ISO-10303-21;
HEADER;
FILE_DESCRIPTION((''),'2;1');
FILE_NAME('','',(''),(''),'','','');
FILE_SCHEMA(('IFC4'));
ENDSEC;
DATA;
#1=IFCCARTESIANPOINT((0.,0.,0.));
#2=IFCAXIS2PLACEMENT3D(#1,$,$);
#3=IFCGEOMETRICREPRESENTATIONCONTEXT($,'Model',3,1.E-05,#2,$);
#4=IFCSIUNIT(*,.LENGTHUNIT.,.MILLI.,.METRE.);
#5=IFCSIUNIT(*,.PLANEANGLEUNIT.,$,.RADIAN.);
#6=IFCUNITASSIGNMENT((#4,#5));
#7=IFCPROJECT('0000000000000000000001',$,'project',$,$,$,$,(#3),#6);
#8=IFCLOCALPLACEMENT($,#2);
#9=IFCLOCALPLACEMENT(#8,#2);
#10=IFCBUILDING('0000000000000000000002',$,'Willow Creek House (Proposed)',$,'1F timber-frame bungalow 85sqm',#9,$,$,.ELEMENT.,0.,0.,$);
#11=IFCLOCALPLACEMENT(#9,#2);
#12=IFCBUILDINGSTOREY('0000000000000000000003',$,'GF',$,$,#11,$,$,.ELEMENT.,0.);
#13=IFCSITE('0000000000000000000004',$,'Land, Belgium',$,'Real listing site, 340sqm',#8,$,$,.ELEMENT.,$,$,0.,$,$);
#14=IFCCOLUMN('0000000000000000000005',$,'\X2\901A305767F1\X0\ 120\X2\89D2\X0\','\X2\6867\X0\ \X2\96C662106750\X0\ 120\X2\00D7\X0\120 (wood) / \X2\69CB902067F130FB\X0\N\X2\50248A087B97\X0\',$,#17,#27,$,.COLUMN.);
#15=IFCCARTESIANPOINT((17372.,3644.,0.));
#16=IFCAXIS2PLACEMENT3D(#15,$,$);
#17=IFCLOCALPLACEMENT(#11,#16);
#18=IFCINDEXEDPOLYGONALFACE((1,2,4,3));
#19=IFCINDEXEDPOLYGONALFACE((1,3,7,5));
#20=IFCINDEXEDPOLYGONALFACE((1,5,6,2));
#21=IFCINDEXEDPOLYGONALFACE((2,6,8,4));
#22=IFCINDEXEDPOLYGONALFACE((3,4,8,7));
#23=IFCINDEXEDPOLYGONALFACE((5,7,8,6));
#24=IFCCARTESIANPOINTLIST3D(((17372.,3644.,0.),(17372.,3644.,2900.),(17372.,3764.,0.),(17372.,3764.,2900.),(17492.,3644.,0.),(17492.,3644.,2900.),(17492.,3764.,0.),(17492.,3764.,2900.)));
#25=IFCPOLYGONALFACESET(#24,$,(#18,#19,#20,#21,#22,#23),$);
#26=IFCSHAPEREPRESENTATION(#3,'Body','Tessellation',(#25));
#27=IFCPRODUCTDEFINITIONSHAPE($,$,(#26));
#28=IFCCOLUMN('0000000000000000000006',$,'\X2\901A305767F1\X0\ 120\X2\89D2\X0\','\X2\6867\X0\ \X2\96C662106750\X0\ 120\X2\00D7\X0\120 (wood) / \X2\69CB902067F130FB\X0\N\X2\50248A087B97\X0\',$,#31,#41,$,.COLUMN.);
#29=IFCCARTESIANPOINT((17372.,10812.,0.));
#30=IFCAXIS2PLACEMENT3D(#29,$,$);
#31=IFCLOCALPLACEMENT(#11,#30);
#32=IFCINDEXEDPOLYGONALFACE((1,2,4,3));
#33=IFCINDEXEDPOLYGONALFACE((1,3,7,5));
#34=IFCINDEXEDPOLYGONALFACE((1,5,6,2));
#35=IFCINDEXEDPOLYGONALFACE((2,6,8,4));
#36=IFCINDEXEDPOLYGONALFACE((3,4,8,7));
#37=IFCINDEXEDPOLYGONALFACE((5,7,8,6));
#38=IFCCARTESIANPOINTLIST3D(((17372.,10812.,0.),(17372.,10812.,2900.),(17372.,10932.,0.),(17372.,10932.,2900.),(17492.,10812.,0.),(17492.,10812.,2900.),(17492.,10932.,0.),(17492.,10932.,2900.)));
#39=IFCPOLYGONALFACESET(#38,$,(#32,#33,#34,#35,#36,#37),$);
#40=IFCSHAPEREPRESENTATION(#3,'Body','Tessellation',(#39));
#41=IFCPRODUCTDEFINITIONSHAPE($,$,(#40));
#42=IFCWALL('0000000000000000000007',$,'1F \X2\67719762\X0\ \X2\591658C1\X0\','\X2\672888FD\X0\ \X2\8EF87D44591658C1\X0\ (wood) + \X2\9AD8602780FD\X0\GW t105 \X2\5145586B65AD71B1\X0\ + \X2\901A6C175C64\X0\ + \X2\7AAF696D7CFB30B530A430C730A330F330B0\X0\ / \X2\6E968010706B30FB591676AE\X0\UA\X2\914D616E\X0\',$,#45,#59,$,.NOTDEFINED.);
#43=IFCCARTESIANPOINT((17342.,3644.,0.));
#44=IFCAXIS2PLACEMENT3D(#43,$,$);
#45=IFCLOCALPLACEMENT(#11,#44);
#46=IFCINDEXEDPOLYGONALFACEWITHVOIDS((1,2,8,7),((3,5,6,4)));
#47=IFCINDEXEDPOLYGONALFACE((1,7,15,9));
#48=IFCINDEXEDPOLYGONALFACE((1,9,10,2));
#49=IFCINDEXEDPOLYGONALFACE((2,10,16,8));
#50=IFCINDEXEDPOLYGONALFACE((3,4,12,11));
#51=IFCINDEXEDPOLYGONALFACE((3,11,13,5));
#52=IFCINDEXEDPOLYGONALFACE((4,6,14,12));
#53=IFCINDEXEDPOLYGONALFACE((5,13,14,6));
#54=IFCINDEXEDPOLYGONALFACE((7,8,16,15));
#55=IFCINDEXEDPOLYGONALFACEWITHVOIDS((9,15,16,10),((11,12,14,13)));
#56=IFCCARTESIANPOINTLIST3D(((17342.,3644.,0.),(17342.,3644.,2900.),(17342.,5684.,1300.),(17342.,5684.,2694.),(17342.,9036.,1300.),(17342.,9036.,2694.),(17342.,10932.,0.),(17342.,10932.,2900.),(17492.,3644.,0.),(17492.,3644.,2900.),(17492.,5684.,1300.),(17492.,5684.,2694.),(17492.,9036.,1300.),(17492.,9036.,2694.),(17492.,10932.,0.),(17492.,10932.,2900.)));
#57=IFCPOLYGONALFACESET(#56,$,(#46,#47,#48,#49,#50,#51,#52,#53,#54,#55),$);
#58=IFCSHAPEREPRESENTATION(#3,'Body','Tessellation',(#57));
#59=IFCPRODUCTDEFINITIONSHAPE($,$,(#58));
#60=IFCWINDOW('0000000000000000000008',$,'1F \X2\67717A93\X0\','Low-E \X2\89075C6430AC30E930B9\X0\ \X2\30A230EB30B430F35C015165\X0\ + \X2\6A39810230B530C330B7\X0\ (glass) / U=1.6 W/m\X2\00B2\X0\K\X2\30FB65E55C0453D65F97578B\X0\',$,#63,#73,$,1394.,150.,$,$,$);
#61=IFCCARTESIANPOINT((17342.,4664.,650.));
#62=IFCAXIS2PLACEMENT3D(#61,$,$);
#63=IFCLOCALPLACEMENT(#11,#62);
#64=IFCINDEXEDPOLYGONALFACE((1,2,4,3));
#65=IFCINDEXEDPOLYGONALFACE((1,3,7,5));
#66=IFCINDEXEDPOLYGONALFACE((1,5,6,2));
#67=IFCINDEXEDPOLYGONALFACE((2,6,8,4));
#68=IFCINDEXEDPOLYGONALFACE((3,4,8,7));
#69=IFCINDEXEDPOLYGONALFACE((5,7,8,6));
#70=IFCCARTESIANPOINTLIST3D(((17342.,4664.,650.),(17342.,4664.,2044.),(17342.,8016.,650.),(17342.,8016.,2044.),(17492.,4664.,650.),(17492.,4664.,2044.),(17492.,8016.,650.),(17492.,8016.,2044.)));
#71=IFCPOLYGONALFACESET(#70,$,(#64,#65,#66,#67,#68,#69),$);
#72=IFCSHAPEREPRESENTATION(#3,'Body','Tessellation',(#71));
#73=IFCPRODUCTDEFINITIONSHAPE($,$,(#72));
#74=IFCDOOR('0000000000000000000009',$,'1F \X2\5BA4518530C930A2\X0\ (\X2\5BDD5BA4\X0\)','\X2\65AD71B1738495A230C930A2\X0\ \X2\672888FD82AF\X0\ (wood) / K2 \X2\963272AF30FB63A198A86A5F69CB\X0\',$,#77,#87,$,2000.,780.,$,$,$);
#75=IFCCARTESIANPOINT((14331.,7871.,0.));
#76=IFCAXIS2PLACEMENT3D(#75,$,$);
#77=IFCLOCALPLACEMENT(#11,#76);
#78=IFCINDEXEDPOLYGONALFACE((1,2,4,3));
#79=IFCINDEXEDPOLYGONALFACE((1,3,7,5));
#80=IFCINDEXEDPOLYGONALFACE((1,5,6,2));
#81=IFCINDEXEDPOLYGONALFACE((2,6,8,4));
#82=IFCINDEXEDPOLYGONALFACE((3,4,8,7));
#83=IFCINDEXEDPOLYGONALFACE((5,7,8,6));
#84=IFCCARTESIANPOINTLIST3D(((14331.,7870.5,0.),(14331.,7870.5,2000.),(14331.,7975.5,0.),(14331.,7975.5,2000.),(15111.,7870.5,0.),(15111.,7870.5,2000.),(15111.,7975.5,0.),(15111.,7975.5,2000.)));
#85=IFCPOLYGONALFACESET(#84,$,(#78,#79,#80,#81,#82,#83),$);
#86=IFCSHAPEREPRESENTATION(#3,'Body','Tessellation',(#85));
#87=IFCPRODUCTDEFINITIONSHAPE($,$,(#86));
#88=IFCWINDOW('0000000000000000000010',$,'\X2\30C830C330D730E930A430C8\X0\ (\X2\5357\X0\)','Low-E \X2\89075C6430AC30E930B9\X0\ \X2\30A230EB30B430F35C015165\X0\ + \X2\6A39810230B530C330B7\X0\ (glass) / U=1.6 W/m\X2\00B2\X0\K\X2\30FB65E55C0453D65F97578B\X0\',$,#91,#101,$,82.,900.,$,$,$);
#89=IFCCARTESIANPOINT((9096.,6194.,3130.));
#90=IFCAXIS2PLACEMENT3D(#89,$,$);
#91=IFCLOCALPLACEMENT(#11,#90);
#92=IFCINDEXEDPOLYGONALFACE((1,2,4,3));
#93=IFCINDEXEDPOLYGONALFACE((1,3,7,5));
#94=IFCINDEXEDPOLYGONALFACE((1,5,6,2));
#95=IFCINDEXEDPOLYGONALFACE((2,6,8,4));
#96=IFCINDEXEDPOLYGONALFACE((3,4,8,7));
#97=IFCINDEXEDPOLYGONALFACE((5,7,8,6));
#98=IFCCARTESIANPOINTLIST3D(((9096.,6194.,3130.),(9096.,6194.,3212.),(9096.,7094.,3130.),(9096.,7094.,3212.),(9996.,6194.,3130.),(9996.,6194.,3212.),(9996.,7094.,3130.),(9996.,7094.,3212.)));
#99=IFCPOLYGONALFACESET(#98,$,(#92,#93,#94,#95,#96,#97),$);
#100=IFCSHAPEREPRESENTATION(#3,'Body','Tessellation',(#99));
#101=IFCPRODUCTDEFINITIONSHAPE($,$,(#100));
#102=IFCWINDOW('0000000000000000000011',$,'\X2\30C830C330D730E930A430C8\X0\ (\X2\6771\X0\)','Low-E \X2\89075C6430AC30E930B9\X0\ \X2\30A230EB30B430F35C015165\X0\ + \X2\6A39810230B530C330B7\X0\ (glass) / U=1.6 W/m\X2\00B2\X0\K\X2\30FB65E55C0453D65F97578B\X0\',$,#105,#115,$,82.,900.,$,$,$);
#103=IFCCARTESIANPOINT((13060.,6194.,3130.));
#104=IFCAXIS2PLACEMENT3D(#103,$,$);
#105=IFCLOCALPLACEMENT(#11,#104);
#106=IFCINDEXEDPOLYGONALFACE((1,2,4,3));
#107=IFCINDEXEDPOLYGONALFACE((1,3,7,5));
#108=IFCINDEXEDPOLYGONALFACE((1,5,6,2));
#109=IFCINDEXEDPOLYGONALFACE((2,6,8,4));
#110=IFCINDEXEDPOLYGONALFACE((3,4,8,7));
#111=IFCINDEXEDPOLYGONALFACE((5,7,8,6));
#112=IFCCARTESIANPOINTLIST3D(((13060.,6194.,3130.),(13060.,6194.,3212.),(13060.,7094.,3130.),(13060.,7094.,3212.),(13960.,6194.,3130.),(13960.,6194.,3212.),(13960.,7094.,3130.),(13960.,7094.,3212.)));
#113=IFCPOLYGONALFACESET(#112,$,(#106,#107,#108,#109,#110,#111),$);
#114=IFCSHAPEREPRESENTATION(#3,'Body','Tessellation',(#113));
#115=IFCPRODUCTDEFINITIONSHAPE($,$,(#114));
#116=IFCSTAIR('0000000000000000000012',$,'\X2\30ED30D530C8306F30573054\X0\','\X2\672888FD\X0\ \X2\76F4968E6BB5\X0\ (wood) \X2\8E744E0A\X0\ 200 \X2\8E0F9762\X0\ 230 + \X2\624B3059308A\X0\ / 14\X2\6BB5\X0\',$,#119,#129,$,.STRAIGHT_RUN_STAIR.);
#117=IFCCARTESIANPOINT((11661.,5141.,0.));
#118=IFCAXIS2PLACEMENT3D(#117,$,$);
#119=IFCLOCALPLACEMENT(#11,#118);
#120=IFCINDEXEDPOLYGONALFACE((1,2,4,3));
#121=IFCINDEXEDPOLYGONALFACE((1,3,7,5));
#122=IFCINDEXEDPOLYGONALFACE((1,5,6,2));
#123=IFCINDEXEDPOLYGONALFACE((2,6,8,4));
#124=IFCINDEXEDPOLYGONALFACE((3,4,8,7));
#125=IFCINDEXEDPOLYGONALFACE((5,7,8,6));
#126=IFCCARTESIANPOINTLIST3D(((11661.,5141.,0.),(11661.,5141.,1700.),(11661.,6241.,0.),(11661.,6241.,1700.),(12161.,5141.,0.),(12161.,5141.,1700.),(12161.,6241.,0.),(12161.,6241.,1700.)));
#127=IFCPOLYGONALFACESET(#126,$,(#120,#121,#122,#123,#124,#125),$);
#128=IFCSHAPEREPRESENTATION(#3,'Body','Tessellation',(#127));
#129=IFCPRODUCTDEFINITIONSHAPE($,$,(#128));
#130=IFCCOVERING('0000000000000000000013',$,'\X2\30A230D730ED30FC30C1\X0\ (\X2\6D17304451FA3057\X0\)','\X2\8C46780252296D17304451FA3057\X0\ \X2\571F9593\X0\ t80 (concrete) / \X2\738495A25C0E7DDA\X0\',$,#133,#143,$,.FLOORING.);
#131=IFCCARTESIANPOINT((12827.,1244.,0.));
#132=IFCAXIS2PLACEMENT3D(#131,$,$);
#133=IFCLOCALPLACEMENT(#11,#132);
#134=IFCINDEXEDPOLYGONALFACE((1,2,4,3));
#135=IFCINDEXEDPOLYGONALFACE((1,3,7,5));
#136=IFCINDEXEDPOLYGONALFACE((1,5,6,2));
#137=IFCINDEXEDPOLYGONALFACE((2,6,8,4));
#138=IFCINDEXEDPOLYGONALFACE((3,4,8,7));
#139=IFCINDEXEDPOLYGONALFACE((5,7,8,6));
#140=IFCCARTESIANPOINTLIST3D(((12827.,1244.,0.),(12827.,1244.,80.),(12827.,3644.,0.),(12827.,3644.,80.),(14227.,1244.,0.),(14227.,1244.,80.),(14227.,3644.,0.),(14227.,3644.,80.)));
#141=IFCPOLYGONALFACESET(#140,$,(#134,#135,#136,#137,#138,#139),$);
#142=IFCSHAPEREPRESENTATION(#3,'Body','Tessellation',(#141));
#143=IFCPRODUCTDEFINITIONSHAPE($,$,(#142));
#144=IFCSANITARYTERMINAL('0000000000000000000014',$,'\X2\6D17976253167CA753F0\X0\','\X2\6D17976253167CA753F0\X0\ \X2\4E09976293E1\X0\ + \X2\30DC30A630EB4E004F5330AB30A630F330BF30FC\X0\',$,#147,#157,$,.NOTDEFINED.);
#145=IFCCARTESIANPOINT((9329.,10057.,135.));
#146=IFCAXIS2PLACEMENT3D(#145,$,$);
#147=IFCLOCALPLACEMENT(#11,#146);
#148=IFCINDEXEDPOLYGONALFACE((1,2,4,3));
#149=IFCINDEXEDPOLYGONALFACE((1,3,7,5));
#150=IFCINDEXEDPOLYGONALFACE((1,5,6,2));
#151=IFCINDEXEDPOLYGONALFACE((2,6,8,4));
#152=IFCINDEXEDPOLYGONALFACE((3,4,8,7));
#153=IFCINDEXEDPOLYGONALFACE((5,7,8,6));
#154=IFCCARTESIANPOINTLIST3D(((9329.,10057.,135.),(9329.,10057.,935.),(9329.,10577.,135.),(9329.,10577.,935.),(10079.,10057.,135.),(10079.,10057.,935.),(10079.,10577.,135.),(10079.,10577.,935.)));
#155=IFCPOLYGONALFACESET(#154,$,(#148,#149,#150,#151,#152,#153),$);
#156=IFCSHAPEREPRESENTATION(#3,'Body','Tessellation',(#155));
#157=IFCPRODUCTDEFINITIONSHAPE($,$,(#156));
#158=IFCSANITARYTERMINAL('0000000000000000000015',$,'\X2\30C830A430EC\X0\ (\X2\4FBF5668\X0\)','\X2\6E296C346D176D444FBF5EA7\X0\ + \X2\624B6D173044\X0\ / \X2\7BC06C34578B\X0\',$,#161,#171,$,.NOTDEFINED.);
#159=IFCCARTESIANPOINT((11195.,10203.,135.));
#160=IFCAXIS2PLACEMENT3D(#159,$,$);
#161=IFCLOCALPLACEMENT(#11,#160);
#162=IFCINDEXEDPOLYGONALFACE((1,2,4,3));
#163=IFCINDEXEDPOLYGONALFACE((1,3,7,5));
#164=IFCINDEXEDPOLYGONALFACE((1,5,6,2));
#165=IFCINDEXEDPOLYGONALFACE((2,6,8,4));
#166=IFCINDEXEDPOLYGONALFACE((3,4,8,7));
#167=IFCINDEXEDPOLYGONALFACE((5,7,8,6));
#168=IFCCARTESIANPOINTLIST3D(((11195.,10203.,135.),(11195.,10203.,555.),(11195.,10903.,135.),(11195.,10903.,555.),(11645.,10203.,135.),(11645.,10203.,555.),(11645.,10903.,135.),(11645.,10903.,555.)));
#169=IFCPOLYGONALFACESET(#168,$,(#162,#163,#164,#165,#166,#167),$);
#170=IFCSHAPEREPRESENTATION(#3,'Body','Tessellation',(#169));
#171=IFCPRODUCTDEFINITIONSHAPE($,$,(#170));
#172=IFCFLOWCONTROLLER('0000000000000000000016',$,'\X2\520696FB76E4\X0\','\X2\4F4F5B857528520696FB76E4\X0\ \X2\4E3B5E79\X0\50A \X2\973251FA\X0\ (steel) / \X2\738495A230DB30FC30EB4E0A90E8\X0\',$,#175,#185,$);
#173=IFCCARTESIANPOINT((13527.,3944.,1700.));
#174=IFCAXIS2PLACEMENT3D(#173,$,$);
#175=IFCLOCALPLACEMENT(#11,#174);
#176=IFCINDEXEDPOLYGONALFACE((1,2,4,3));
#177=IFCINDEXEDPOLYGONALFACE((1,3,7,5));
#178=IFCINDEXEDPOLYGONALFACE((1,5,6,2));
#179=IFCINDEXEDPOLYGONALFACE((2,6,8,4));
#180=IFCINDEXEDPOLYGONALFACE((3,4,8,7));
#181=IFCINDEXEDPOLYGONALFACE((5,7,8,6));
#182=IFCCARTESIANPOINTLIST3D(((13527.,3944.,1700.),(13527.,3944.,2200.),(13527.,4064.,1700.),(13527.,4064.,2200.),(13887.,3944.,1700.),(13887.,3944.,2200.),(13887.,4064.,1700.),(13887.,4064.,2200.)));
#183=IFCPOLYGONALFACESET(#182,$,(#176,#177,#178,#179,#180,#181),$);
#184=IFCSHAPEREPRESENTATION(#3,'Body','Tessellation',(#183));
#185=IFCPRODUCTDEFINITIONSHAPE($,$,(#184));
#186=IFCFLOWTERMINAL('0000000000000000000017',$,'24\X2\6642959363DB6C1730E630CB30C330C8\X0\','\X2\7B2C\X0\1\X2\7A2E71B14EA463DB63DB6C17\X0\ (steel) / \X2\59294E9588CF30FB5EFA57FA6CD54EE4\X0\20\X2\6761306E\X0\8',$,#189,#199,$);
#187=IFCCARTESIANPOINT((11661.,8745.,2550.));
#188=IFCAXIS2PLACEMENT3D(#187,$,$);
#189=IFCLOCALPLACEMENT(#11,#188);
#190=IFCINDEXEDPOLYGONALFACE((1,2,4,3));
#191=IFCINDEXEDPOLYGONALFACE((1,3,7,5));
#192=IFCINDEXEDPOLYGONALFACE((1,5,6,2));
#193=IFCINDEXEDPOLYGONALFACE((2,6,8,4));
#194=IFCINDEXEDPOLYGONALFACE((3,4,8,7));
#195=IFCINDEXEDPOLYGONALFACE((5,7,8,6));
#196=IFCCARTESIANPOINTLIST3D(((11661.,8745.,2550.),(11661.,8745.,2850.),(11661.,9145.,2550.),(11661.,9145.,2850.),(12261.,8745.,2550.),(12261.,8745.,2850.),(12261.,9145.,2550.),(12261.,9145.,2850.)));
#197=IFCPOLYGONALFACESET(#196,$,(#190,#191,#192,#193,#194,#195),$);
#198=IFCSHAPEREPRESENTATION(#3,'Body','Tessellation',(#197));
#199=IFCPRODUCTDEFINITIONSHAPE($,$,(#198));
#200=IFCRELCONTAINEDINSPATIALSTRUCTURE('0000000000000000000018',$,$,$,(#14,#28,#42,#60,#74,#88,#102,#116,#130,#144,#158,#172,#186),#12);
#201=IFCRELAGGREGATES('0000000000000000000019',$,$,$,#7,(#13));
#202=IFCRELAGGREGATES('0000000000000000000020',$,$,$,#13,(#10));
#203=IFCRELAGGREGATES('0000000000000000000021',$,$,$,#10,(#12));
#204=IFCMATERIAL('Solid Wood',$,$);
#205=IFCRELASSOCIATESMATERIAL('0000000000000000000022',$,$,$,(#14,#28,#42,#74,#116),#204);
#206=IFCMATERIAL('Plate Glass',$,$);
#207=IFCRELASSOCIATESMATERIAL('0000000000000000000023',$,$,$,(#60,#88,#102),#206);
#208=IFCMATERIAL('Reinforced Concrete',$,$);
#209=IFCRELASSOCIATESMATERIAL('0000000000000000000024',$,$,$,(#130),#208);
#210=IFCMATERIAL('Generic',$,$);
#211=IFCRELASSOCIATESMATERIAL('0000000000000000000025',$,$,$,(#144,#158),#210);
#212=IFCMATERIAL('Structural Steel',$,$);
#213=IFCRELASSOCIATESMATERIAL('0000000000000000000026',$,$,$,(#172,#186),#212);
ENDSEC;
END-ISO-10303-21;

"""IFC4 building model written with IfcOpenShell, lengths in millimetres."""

from ifc_helpers import new_model, si_unit, frame, frame_2d, origin, place, context, project, spatial, rectangle, extrude, material, element, fill, save


model = new_model("IFC4")

# Units and contexts
model_context = context("Model", 3, precision=1e-05, world=origin())
ifc_project = project(units=[si_unit("LENGTHUNIT", "METRE", prefix="MILLI"), si_unit("PLANEANGLEUNIT", "RADIAN")], contexts=[model_context])

# Site, building, storey
site_placement = place(None, origin())
site = spatial("IfcSite", under=ifc_project, at=site_placement, Name="Land, Belgium", ObjectType="Real listing site, 340sqm", CompositionType="ELEMENT", RefElevation=0.0)
building_placement = place(site_placement, origin())
building = spatial("IfcBuilding", under=site, at=building_placement, Name="Willow Creek House (Proposed)", ObjectType="1F timber-frame bungalow 85sqm", CompositionType="ELEMENT", ElevationOfRefHeight=0.0, ElevationOfTerrain=0.0)
storey_placement = place(building_placement, origin())
storey = spatial("IfcBuildingStorey", under=building, at=storey_placement, Name="GF", CompositionType="ELEMENT", Elevation=0.0)

# Columns
ifc_material_1 = material(Name="Solid Wood")
column_1_placement = place(storey_placement, frame((17372.0, 3644.0, 0.0)))
element("IfcColumn", 1, at=column_1_placement, inside=storey, material=ifc_material_1, Name="通し柱 120角", Description="桧 集成材 120×120 (wood) / 構造柱・N値計算", PredefinedType="COLUMN", context=model_context, shape_type="SweptSolid", body=[
    extrude(rectangle(XDim=120.0, YDim=120.0, at=frame_2d((60.0, 60.0))), frame((17372.0, 3644.0, 0.0)), (0.0, 0.0, 1.0), 2900.0),
])
column_2_placement = place(storey_placement, frame((17372.0, 10812.0, 0.0)))
element("IfcColumn", 2, at=column_2_placement, inside=storey, material=ifc_material_1, Name="通し柱 120角", Description="桧 集成材 120×120 (wood) / 構造柱・N値計算", PredefinedType="COLUMN", context=model_context, shape_type="SweptSolid", body=[
    extrude(rectangle(XDim=120.0, YDim=120.0, at=frame_2d((60.0, 60.0))), frame((17372.0, 10812.0, 0.0)), (0.0, 0.0, 1.0), 2900.0),
])

# Wall, opening, window
wall_1_placement = place(storey_placement, frame((17342.0, 3644.0, 0.0)))
wall_1 = element("IfcWall", 3, at=wall_1_placement, inside=storey, material=ifc_material_1, Name="1F 東面 外壁", Description="木製 軸組外壁 (wood) + 高性能GW t105 充填断熱 + 通気層 + 窯業系サイディング / 準耐火・外皮UA配慮", PredefinedType="NOTDEFINED", context=model_context, shape_type="SweptSolid", body=[
    extrude(rectangle(XDim=150.0, YDim=7288.0, at=frame_2d((75.0, 3644.0))), frame((17342.0, 3644.0, 0.0)), (0.0, 0.0, 1.0), 2900.0),
])
opening_placement = place(storey_placement, frame((17342.0, 4664.0, 650.0)))
opening = element("IfcOpeningElement", 4, at=opening_placement, cuts=wall_1, PredefinedType="NOTDEFINED", context=model_context, shape_type="SweptSolid", body=[
    extrude(rectangle(XDim=150.0, YDim=3352.0, at=frame_2d((75.0, 1676.0))), frame((17342.0, 4664.0, 650.0)), (0.0, 0.0, 1.0), 1394.0),
])
ifc_material_2 = material(Name="Plate Glass")
window_1_placement = place(storey_placement, frame((17342.0, 4664.0, 650.0)))
window_1 = element("IfcWindow", 5, at=window_1_placement, inside=storey, material=ifc_material_2, Name="1F 東窓", Description="Low-E 複層ガラス アルゴン封入 + 樹脂サッシ (glass) / U=1.6 W/m²K・日射取得型", OverallHeight=1394.0, OverallWidth=150.0, context=model_context, shape_type="SweptSolid", body=[
    extrude(rectangle(XDim=150.0, YDim=3352.0, at=frame_2d((75.0, 1676.0))), frame((17342.0, 4664.0, 650.0)), (0.0, 0.0, 1.0), 1394.0),
])
fill(opening, window_1)

# Door
door_placement = place(storey_placement, frame((14331.0, 7871.0, 0.0)))
element("IfcDoor", 6, at=door_placement, inside=storey, material=ifc_material_1, Name="1F 室内ドア (寝室)", Description="断熱玄関ドア 木製芯 (wood) / K2 防犯・採風機構", OverallHeight=2000.0, OverallWidth=780.0, context=model_context, shape_type="SweptSolid", body=[
    extrude(rectangle(XDim=780.0, YDim=105.0, at=frame_2d((390.0, 52.0))), frame((14331.0, 7871.0, 0.0)), (0.0, 0.0, 1.0), 2000.0),
])

# Windows
window_2_placement = place(storey_placement, frame((9096.0, 6194.0, 3130.0)))
element("IfcWindow", 7, at=window_2_placement, inside=storey, material=ifc_material_2, Name="トップライト (南)", Description="Low-E 複層ガラス アルゴン封入 + 樹脂サッシ (glass) / U=1.6 W/m²K・日射取得型", OverallHeight=82.0, OverallWidth=900.0, context=model_context, shape_type="SweptSolid", body=[
    extrude(rectangle(XDim=900.0, YDim=900.0, at=frame_2d((450.0, 450.0))), frame((9096.0, 6194.0, 3130.0)), (0.0, 0.0, 1.0), 82.0),
])
window_3_placement = place(storey_placement, frame((13060.0, 6194.0, 3130.0)))
element("IfcWindow", 8, at=window_3_placement, inside=storey, material=ifc_material_2, Name="トップライト (東)", Description="Low-E 複層ガラス アルゴン封入 + 樹脂サッシ (glass) / U=1.6 W/m²K・日射取得型", OverallHeight=82.0, OverallWidth=900.0, context=model_context, shape_type="SweptSolid", body=[
    extrude(rectangle(XDim=900.0, YDim=900.0, at=frame_2d((450.0, 450.0))), frame((13060.0, 6194.0, 3130.0)), (0.0, 0.0, 1.0), 82.0),
])

# Stair
stair_placement = place(storey_placement, frame((11661.0, 5141.0, 0.0)))
element("IfcStair", 9, at=stair_placement, inside=storey, material=ifc_material_1, Name="ロフトはしご", Description="木製 直階段 (wood) 蹴上 200 踏面 230 + 手すり / 14段", PredefinedType="STRAIGHT_RUN_STAIR", context=model_context, shape_type="SweptSolid", body=[
    extrude(rectangle(XDim=500.0, YDim=1100.0, at=frame_2d((250.0, 550.0))), frame((11661.0, 5141.0, 0.0)), (0.0, 0.0, 1.0), 1700.0),
])

# Covering
ifc_material_3 = material(Name="Reinforced Concrete")
covering_placement = place(storey_placement, frame((12827.0, 1244.0, 0.0)))
element("IfcCovering", 10, at=covering_placement, inside=storey, material=ifc_material_3, Name="アプローチ (洗い出し)", Description="豆砂利洗い出し 土間 t80 (concrete) / 玄関導線", PredefinedType="FLOORING", context=model_context, shape_type="SweptSolid", body=[
    extrude(rectangle(XDim=1400.0, YDim=2400.0, at=frame_2d((700.0, 1200.0))), frame((12827.0, 1244.0, 0.0)), (0.0, 0.0, 1.0), 80.0),
])

# Sanitary terminals
ifc_material_4 = material(Name="Generic")
sanitary_terminal_1_placement = place(storey_placement, frame((9329.0, 10057.0, 135.0)))
element("IfcSanitaryTerminal", 11, at=sanitary_terminal_1_placement, inside=storey, material=ifc_material_4, Name="洗面化粧台", Description="洗面化粧台 三面鏡 + ボウル一体カウンター", PredefinedType="NOTDEFINED", context=model_context, shape_type="SweptSolid", body=[
    extrude(rectangle(XDim=750.0, YDim=520.0, at=frame_2d((375.0, 260.0))), frame((9329.0, 10057.0, 135.0)), (0.0, 0.0, 1.0), 800.0),
])
sanitary_terminal_2_placement = place(storey_placement, frame((11195.0, 10203.0, 135.0)))
element("IfcSanitaryTerminal", 12, at=sanitary_terminal_2_placement, inside=storey, material=ifc_material_4, Name="トイレ (便器)", Description="温水洗浄便座 + 手洗い / 節水型", PredefinedType="NOTDEFINED", context=model_context, shape_type="SweptSolid", body=[
    extrude(rectangle(XDim=450.0, YDim=700.0, at=frame_2d((225.0, 350.0))), frame((11195.0, 10203.0, 135.0)), (0.0, 0.0, 1.0), 420.0),
])

# Flow controller
ifc_material_5 = material(Name="Structural Steel")
flow_controller_placement = place(storey_placement, frame((13527.0, 3944.0, 1700.0)))
element("IfcFlowController", 13, at=flow_controller_placement, inside=storey, material=ifc_material_5, Name="分電盤", Description="住宅用分電盤 主幹50A 露出 (steel) / 玄関ホール上部", context=model_context, shape_type="SweptSolid", body=[
    extrude(rectangle(XDim=360.0, YDim=120.0, at=frame_2d((180.0, 60.0))), frame((13527.0, 3944.0, 1700.0)), (0.0, 0.0, 1.0), 500.0),
])

# Flow terminal
flow_terminal_1_placement = place(storey_placement, frame((11661.0, 8745.0, 2550.0)))
element("IfcFlowTerminal", 14, at=flow_terminal_1_placement, inside=storey, material=ifc_material_5, Name="24時間換気ユニット", Description="第1種熱交換換気 (steel) / 天井裏・建基法令20条の8", context=model_context, shape_type="SweptSolid", body=[
    extrude(rectangle(XDim=600.0, YDim=400.0, at=frame_2d((300.0, 200.0))), frame((11661.0, 8745.0, 2550.0)), (0.0, 0.0, 1.0), 300.0),
])

save(model, "model.ifc")
